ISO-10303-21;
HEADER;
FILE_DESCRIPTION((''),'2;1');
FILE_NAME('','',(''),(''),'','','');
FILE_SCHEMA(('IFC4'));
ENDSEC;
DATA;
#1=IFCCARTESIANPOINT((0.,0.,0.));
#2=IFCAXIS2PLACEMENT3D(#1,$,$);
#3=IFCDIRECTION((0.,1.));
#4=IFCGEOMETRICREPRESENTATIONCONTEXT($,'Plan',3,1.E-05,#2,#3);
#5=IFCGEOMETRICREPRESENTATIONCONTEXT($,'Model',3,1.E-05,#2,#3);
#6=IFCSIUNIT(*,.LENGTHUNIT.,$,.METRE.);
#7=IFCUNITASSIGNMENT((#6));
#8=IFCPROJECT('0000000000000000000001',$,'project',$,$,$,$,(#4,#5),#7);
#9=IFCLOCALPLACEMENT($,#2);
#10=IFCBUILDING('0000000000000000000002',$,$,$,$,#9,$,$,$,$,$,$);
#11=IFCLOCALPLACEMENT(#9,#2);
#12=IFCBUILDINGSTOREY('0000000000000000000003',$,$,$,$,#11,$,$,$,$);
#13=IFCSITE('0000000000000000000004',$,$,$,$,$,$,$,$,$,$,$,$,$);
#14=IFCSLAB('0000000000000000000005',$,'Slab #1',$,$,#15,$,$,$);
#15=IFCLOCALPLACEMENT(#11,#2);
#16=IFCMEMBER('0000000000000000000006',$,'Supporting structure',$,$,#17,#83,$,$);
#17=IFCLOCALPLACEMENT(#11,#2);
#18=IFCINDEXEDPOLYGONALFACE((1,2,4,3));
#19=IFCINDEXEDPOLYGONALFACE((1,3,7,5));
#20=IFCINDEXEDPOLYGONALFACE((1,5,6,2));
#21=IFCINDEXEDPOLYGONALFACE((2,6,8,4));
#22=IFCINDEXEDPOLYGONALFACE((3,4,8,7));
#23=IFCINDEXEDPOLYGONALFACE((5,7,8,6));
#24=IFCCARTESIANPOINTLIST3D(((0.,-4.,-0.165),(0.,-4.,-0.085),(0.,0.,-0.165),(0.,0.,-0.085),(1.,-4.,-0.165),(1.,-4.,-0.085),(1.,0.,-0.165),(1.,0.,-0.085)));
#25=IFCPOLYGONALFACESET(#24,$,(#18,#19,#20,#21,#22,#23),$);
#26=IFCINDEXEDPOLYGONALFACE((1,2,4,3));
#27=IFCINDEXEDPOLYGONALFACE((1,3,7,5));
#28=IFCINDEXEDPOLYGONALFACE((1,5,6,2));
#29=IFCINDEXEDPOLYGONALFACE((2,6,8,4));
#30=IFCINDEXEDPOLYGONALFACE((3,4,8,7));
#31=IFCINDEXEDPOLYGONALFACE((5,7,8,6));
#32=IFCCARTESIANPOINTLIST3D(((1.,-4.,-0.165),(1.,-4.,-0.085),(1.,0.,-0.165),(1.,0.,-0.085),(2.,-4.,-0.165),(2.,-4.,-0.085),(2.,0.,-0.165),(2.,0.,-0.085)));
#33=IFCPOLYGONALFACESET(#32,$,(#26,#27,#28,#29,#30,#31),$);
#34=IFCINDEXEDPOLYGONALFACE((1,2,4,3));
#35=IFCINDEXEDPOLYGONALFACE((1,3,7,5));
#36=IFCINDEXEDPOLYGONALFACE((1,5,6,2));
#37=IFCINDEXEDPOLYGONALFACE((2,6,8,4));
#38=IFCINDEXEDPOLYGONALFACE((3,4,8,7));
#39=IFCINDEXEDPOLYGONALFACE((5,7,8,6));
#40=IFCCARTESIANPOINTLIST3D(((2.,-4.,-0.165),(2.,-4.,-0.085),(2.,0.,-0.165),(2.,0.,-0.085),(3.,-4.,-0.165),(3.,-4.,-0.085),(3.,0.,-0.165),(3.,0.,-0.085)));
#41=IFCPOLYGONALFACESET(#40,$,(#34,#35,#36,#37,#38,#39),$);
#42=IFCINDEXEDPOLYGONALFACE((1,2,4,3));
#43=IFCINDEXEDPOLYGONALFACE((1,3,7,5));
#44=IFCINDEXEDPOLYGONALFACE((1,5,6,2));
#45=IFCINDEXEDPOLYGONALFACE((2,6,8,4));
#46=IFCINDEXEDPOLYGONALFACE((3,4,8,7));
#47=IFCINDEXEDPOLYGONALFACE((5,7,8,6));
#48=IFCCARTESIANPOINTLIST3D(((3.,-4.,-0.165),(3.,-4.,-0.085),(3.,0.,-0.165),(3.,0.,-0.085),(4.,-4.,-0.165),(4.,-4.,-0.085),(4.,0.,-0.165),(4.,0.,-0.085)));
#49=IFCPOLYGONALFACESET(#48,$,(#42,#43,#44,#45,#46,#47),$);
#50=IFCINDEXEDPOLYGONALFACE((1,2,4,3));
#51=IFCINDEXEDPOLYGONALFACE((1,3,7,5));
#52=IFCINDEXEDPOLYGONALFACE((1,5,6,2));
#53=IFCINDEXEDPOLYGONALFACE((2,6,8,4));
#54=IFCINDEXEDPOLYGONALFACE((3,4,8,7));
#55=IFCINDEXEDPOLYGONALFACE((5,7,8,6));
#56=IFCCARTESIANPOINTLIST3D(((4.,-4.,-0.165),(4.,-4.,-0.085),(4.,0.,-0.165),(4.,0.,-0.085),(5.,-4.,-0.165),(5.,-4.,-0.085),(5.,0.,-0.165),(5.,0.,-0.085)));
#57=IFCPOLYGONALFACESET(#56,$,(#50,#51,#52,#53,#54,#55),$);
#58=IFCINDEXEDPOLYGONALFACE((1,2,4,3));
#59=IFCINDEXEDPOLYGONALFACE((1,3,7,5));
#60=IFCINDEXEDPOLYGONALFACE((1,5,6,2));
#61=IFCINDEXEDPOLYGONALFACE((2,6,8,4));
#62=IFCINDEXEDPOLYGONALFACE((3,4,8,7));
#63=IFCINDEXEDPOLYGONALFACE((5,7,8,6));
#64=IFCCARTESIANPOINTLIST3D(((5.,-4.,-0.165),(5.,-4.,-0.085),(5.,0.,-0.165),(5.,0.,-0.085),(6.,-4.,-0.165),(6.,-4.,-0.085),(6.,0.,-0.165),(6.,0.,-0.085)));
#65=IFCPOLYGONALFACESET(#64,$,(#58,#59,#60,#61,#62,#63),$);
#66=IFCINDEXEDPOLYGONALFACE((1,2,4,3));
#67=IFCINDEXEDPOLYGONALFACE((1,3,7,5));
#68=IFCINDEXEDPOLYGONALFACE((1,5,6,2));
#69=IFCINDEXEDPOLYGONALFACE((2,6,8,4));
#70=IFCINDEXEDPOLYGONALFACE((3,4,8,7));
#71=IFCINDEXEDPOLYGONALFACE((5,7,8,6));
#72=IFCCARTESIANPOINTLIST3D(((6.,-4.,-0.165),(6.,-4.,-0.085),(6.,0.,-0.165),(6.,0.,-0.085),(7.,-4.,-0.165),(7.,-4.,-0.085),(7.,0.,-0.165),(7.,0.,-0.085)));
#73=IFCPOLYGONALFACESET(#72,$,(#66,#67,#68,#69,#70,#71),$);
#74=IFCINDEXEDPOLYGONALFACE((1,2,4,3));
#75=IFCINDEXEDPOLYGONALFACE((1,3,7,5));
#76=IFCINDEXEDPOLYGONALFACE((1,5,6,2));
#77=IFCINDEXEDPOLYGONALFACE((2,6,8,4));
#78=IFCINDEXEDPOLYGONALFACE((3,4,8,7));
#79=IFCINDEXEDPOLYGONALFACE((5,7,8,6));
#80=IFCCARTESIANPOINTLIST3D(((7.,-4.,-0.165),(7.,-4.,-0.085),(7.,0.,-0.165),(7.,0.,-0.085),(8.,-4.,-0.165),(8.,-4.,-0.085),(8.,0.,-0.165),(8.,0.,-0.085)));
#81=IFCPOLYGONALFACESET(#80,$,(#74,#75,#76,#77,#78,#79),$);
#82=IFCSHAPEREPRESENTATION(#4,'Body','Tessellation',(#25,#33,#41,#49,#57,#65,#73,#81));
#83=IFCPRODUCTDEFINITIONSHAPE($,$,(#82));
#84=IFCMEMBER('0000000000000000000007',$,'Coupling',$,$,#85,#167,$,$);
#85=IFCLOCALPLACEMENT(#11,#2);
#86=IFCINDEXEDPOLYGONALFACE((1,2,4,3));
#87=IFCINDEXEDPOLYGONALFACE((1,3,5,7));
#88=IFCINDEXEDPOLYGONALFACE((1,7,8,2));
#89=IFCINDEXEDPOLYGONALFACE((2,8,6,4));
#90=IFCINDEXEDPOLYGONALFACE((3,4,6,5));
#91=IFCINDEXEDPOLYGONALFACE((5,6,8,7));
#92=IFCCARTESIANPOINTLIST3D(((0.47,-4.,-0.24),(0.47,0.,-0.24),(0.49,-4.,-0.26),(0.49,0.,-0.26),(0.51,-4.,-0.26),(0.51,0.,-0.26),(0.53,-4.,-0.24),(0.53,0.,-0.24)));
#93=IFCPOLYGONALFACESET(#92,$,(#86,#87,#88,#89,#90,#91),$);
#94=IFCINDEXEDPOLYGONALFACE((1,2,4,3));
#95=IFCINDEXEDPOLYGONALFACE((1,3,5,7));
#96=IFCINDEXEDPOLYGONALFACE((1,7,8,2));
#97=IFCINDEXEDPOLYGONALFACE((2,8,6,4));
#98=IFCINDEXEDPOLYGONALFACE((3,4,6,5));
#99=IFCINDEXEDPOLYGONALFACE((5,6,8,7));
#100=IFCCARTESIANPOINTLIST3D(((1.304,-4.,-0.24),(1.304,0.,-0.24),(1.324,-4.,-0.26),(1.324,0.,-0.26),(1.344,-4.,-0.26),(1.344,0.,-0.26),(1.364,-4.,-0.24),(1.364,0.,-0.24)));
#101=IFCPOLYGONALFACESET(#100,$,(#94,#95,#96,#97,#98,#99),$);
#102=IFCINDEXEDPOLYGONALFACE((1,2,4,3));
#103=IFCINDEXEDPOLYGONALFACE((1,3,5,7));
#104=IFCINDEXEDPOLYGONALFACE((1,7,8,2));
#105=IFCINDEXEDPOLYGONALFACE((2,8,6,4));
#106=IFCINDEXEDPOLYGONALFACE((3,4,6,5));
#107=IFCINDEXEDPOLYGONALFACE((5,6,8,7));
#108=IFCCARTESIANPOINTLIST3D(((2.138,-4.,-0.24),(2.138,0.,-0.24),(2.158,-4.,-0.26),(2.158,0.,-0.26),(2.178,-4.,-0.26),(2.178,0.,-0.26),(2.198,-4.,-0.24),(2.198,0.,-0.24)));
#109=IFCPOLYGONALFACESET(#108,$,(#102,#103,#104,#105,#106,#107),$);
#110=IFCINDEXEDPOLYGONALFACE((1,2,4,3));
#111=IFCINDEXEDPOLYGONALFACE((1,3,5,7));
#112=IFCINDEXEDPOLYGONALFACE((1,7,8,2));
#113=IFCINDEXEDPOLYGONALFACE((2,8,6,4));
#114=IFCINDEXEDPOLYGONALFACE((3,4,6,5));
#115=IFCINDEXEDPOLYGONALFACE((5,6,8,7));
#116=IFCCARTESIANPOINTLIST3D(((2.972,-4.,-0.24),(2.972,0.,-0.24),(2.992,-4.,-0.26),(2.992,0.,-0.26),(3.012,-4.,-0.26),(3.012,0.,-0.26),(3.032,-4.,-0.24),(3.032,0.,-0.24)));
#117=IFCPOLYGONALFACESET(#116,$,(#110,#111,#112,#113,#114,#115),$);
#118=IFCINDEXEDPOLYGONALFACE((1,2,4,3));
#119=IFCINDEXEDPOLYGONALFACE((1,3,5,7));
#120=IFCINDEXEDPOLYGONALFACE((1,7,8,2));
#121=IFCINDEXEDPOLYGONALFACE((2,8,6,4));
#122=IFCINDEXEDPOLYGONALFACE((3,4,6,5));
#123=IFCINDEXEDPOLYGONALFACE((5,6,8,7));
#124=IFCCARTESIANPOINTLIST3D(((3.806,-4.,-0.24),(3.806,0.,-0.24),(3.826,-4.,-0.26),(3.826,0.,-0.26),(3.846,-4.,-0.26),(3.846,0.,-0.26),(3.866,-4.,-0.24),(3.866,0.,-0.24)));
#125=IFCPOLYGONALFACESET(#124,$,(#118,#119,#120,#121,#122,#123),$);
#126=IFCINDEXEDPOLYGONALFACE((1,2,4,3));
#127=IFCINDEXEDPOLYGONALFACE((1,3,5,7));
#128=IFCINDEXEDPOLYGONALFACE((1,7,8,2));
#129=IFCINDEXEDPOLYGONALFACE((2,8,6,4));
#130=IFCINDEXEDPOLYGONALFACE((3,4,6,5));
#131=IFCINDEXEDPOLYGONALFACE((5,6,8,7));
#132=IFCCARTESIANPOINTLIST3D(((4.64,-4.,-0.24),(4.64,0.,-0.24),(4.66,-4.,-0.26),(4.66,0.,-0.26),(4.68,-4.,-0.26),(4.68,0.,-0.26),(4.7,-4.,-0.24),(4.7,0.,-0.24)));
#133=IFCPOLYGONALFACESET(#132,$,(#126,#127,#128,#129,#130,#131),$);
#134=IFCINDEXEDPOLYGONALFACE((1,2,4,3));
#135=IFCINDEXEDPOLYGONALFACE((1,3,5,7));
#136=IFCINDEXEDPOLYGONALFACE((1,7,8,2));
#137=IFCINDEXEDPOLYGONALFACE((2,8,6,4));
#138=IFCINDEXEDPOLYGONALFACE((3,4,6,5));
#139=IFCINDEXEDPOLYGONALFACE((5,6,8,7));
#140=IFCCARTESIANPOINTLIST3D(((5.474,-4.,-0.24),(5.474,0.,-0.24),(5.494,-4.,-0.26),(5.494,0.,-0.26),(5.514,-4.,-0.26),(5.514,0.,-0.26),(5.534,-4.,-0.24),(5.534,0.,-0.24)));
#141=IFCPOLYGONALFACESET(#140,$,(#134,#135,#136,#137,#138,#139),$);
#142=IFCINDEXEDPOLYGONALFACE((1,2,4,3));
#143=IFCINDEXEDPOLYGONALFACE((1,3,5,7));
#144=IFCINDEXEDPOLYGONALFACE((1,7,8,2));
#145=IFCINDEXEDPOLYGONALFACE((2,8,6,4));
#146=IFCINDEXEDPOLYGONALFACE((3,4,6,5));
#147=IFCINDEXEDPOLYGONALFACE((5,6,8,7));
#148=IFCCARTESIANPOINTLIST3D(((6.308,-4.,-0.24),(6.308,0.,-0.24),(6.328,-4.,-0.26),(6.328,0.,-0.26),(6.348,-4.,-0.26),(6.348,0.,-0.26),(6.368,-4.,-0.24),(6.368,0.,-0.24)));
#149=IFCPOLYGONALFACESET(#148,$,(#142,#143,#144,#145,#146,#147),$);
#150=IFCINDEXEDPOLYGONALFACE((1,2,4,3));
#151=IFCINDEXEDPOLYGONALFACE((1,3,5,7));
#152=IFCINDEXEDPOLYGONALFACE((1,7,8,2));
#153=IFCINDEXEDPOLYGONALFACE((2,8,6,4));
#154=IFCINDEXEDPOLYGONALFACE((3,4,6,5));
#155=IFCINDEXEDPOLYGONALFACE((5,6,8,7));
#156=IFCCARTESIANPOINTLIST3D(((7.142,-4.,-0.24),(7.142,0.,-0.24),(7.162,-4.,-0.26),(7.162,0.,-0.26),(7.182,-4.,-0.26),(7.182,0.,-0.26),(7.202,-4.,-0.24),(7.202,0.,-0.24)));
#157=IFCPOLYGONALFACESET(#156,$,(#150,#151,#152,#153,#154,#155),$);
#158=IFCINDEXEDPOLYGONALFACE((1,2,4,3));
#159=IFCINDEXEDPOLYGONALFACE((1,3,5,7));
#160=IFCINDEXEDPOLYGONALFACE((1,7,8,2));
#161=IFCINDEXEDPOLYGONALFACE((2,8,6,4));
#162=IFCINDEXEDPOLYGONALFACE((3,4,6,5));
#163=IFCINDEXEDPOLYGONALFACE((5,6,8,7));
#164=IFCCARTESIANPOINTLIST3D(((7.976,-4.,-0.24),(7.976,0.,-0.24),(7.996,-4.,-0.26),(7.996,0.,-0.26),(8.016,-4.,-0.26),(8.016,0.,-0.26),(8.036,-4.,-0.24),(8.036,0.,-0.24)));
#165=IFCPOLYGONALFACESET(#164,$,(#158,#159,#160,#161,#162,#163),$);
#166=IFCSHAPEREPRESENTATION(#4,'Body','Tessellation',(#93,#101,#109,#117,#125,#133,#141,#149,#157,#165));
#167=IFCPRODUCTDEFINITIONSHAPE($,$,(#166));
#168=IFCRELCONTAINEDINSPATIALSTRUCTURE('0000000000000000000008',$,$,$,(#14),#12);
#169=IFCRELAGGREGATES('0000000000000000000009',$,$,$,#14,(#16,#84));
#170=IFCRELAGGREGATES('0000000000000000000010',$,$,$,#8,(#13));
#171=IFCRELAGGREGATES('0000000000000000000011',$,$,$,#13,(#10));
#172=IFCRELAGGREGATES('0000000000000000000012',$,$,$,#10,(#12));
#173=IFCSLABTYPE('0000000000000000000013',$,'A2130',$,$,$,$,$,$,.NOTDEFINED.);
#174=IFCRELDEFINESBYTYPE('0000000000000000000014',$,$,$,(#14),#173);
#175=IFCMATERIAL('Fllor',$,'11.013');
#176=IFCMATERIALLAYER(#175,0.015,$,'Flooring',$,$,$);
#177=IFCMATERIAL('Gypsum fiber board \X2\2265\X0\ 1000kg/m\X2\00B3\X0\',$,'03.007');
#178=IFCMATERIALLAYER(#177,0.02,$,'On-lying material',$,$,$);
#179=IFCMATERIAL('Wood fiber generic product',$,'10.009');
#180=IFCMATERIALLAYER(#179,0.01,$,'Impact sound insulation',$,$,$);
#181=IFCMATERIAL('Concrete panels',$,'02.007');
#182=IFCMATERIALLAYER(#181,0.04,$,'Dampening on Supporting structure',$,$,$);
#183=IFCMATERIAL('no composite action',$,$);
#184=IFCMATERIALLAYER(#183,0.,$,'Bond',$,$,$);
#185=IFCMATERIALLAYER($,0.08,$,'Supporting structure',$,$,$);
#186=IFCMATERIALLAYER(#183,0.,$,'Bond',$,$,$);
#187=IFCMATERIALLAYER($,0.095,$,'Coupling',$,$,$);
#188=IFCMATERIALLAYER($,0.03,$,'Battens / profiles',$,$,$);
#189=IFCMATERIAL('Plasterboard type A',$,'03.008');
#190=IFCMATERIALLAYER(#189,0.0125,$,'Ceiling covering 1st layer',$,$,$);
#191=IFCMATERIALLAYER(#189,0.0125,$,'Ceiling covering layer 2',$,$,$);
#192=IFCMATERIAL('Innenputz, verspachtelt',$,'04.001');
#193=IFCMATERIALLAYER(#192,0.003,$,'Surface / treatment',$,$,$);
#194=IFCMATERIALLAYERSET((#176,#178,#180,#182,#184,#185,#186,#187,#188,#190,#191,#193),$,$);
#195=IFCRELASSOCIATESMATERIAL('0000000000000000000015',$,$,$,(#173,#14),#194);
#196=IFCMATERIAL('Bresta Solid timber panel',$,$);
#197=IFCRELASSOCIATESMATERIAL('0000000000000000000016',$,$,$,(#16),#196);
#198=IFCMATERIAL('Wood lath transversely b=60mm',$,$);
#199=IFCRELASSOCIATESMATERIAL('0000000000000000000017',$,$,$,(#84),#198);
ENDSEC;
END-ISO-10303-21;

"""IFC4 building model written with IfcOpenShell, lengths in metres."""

from ifc_helpers import new_model, si_unit, direction, frame, frame_2d, origin, place, context, project, spatial, polyline, rectangle, outline, extrude, material, layer, layer_set, type_object, element, aggregate, save


model = new_model("IFC4")

# Units and contexts
plan_context = context("Plan", 3, precision=1e-05, world=origin(), true_north=direction((0.0, 1.0)))
model_context = context("Model", 3, precision=1e-05, world=origin(), true_north=direction((0.0, 1.0)))
ifc_project = project(units=[si_unit("LENGTHUNIT", "METRE")], contexts=[plan_context, model_context])

# Site, building, storey
site = spatial("IfcSite", under=ifc_project)
building_placement = place(None, origin())
building = spatial("IfcBuilding", under=site, at=building_placement)
storey_placement = place(building_placement, origin())
storey = spatial("IfcBuildingStorey", under=building, at=storey_placement)

# Slab, members
ifc_material_1 = material(Name="Fllor", Category="11.013")
ifc_layer_1 = layer(ifc_material_1, 0.015, Name="Flooring")
ifc_material_2 = material(Name="Gypsum fiber board ≥ 1000kg/m³", Category="03.007")
ifc_layer_2 = layer(ifc_material_2, 0.02, Name="On-lying material")
ifc_material_3 = material(Name="Wood fiber generic product", Category="10.009")
ifc_layer_3 = layer(ifc_material_3, 0.01, Name="Impact sound insulation")
ifc_material_4 = material(Name="Concrete panels", Category="02.007")
ifc_layer_4 = layer(ifc_material_4, 0.04, Name="Dampening on Supporting structure")
ifc_material_5 = material(Name="no composite action")
ifc_layer_5 = layer(ifc_material_5, 0.0, Name="Bond")
ifc_layer_6 = layer(None, 0.08, Name="Supporting structure")
ifc_layer_7 = layer(ifc_material_5, 0.0, Name="Bond")
ifc_layer_8 = layer(None, 0.095, Name="Coupling")
ifc_layer_9 = layer(None, 0.03, Name="Battens / profiles")
ifc_material_6 = material(Name="Plasterboard type A", Category="03.008")
ifc_layer_10 = layer(ifc_material_6, 0.0125, Name="Ceiling covering 1st layer")
ifc_layer_11 = layer(ifc_material_6, 0.0125, Name="Ceiling covering layer 2")
ifc_material_7 = material(Name="Innenputz, verspachtelt", Category="04.001")
ifc_layer_12 = layer(ifc_material_7, 0.003, Name="Surface / treatment")
ifc_layer_set = layer_set([ifc_layer_1, ifc_layer_2, ifc_layer_3, ifc_layer_4, ifc_layer_5, ifc_layer_6, ifc_layer_7, ifc_layer_8, ifc_layer_9, ifc_layer_10, ifc_layer_11, ifc_layer_12])
slab_type = type_object("IfcSlabType", Name="A2130", PredefinedType="NOTDEFINED", material=ifc_layer_set)
slab_placement = place(None, frame((0.0, 0.0, 0.0), z_axis=(0.0, 0.0, -1.0), x_axis=(1.0, 0.0, 0.0)))
slab = element("IfcSlab", 1, at=slab_placement, inside=storey, type_object=slab_type, material=ifc_layer_set, Name="Slab #1")
ifc_material_8 = material(Name="Bresta Solid timber panel")
member_1_placement = place(slab_placement, origin())
member_1 = element("IfcMember", 2, at=member_1_placement, material=ifc_material_8, Name="Supporting structure", context=plan_context, shape_type="SweptSolid", body=[
    extrude(rectangle(XDim=1.0, YDim=0.08, at=frame_2d((0.5, 0.04), x_axis=(1.0, 0.0))), frame((0.0, 4.0, 0.085), z_axis=(0.0, -1.0, 0.0), x_axis=(1.0, 0.0, 0.0)), (0.0, 0.0, 1.0), 4.0),
    extrude(rectangle(XDim=1.0, YDim=0.08, at=frame_2d((0.5, 0.04), x_axis=(1.0, 0.0))), frame((1.0, 4.0, 0.085), z_axis=(0.0, -1.0, 0.0), x_axis=(1.0, 0.0, 0.0)), (0.0, 0.0, 1.0), 4.0),
    extrude(rectangle(XDim=1.0, YDim=0.08, at=frame_2d((0.5, 0.04), x_axis=(1.0, 0.0))), frame((2.0, 4.0, 0.085), z_axis=(0.0, -1.0, 0.0), x_axis=(1.0, 0.0, 0.0)), (0.0, 0.0, 1.0), 4.0),
    extrude(rectangle(XDim=1.0, YDim=0.08, at=frame_2d((0.5, 0.04), x_axis=(1.0, 0.0))), frame((3.0, 4.0, 0.085), z_axis=(0.0, -1.0, 0.0), x_axis=(1.0, 0.0, 0.0)), (0.0, 0.0, 1.0), 4.0),
    extrude(rectangle(XDim=1.0, YDim=0.08, at=frame_2d((0.5, 0.04), x_axis=(1.0, 0.0))), frame((4.0, 4.0, 0.085), z_axis=(0.0, -1.0, 0.0), x_axis=(1.0, 0.0, 0.0)), (0.0, 0.0, 1.0), 4.0),
    extrude(rectangle(XDim=1.0, YDim=0.08, at=frame_2d((0.5, 0.04), x_axis=(1.0, 0.0))), frame((5.0, 4.0, 0.085), z_axis=(0.0, -1.0, 0.0), x_axis=(1.0, 0.0, 0.0)), (0.0, 0.0, 1.0), 4.0),
    extrude(rectangle(XDim=1.0, YDim=0.08, at=frame_2d((0.5, 0.04), x_axis=(1.0, 0.0))), frame((6.0, 4.0, 0.085), z_axis=(0.0, -1.0, 0.0), x_axis=(1.0, 0.0, 0.0)), (0.0, 0.0, 1.0), 4.0),
    extrude(rectangle(XDim=1.0, YDim=0.08, at=frame_2d((0.5, 0.04), x_axis=(1.0, 0.0))), frame((7.0, 4.0, 0.085), z_axis=(0.0, -1.0, 0.0), x_axis=(1.0, 0.0, 0.0)), (0.0, 0.0, 1.0), 4.0),
])
ifc_material_9 = material(Name="Wood lath transversely b=60mm")
member_2_placement = place(slab_placement, origin())
member_2 = element("IfcMember", 3, at=member_2_placement, material=ifc_material_9, Name="Coupling", context=plan_context, shape_type="SweptSolid", body=[
    extrude(outline(polyline([(0.0, 0.0), (0.06, 0.0), (0.04, 0.02), (0.02, 0.02), (0.0, 0.0)])), frame((0.47, 4.0, 0.24), z_axis=(0.0, -1.0, 0.0), x_axis=(1.0, 0.0, 0.0)), (0.0, 0.0, 1.0), 4.0),
    extrude(outline(polyline([(0.0, 0.0), (0.06, 0.0), (0.04, 0.02), (0.02, 0.02), (0.0, 0.0)])), frame((1.304, 4.0, 0.24), z_axis=(0.0, -1.0, 0.0), x_axis=(1.0, 0.0, 0.0)), (0.0, 0.0, 1.0), 4.0),
    extrude(outline(polyline([(0.0, 0.0), (0.06, 0.0), (0.04, 0.02), (0.02, 0.02), (0.0, 0.0)])), frame((2.138, 4.0, 0.24), z_axis=(0.0, -1.0, 0.0), x_axis=(1.0, 0.0, 0.0)), (0.0, 0.0, 1.0), 4.0),
    extrude(outline(polyline([(0.0, 0.0), (0.06, 0.0), (0.04, 0.02), (0.02, 0.02), (0.0, 0.0)])), frame((2.972, 4.0, 0.24), z_axis=(0.0, -1.0, 0.0), x_axis=(1.0, 0.0, 0.0)), (0.0, 0.0, 1.0), 4.0),
    extrude(outline(polyline([(0.0, 0.0), (0.06, 0.0), (0.04, 0.02), (0.02, 0.02), (0.0, 0.0)])), frame((3.806, 4.0, 0.24), z_axis=(0.0, -1.0, 0.0), x_axis=(1.0, 0.0, 0.0)), (0.0, 0.0, 1.0), 4.0),
    extrude(outline(polyline([(0.0, 0.0), (0.06, 0.0), (0.04, 0.02), (0.02, 0.02), (0.0, 0.0)])), frame((4.64, 4.0, 0.24), z_axis=(0.0, -1.0, 0.0), x_axis=(1.0, 0.0, 0.0)), (0.0, 0.0, 1.0), 4.0),
    extrude(outline(polyline([(0.0, 0.0), (0.06, 0.0), (0.04, 0.02), (0.02, 0.02), (0.0, 0.0)])), frame((5.474, 4.0, 0.24), z_axis=(0.0, -1.0, 0.0), x_axis=(1.0, 0.0, 0.0)), (0.0, 0.0, 1.0), 4.0),
    extrude(outline(polyline([(0.0, 0.0), (0.06, 0.0), (0.04, 0.02), (0.02, 0.02), (0.0, 0.0)])), frame((6.308, 4.0, 0.24), z_axis=(0.0, -1.0, 0.0), x_axis=(1.0, 0.0, 0.0)), (0.0, 0.0, 1.0), 4.0),
    extrude(outline(polyline([(0.0, 0.0), (0.06, 0.0), (0.04, 0.02), (0.02, 0.02), (0.0, 0.0)])), frame((7.142, 4.0, 0.24), z_axis=(0.0, -1.0, 0.0), x_axis=(1.0, 0.0, 0.0)), (0.0, 0.0, 1.0), 4.0),
    extrude(outline(polyline([(0.0, 0.0), (0.06, 0.0), (0.04, 0.02), (0.02, 0.02), (0.0, 0.0)])), frame((7.976, 4.0, 0.24), z_axis=(0.0, -1.0, 0.0), x_axis=(1.0, 0.0, 0.0)), (0.0, 0.0, 1.0), 4.0),
])
aggregate(slab, [member_1, member_2])

save(model, "model.ifc")
